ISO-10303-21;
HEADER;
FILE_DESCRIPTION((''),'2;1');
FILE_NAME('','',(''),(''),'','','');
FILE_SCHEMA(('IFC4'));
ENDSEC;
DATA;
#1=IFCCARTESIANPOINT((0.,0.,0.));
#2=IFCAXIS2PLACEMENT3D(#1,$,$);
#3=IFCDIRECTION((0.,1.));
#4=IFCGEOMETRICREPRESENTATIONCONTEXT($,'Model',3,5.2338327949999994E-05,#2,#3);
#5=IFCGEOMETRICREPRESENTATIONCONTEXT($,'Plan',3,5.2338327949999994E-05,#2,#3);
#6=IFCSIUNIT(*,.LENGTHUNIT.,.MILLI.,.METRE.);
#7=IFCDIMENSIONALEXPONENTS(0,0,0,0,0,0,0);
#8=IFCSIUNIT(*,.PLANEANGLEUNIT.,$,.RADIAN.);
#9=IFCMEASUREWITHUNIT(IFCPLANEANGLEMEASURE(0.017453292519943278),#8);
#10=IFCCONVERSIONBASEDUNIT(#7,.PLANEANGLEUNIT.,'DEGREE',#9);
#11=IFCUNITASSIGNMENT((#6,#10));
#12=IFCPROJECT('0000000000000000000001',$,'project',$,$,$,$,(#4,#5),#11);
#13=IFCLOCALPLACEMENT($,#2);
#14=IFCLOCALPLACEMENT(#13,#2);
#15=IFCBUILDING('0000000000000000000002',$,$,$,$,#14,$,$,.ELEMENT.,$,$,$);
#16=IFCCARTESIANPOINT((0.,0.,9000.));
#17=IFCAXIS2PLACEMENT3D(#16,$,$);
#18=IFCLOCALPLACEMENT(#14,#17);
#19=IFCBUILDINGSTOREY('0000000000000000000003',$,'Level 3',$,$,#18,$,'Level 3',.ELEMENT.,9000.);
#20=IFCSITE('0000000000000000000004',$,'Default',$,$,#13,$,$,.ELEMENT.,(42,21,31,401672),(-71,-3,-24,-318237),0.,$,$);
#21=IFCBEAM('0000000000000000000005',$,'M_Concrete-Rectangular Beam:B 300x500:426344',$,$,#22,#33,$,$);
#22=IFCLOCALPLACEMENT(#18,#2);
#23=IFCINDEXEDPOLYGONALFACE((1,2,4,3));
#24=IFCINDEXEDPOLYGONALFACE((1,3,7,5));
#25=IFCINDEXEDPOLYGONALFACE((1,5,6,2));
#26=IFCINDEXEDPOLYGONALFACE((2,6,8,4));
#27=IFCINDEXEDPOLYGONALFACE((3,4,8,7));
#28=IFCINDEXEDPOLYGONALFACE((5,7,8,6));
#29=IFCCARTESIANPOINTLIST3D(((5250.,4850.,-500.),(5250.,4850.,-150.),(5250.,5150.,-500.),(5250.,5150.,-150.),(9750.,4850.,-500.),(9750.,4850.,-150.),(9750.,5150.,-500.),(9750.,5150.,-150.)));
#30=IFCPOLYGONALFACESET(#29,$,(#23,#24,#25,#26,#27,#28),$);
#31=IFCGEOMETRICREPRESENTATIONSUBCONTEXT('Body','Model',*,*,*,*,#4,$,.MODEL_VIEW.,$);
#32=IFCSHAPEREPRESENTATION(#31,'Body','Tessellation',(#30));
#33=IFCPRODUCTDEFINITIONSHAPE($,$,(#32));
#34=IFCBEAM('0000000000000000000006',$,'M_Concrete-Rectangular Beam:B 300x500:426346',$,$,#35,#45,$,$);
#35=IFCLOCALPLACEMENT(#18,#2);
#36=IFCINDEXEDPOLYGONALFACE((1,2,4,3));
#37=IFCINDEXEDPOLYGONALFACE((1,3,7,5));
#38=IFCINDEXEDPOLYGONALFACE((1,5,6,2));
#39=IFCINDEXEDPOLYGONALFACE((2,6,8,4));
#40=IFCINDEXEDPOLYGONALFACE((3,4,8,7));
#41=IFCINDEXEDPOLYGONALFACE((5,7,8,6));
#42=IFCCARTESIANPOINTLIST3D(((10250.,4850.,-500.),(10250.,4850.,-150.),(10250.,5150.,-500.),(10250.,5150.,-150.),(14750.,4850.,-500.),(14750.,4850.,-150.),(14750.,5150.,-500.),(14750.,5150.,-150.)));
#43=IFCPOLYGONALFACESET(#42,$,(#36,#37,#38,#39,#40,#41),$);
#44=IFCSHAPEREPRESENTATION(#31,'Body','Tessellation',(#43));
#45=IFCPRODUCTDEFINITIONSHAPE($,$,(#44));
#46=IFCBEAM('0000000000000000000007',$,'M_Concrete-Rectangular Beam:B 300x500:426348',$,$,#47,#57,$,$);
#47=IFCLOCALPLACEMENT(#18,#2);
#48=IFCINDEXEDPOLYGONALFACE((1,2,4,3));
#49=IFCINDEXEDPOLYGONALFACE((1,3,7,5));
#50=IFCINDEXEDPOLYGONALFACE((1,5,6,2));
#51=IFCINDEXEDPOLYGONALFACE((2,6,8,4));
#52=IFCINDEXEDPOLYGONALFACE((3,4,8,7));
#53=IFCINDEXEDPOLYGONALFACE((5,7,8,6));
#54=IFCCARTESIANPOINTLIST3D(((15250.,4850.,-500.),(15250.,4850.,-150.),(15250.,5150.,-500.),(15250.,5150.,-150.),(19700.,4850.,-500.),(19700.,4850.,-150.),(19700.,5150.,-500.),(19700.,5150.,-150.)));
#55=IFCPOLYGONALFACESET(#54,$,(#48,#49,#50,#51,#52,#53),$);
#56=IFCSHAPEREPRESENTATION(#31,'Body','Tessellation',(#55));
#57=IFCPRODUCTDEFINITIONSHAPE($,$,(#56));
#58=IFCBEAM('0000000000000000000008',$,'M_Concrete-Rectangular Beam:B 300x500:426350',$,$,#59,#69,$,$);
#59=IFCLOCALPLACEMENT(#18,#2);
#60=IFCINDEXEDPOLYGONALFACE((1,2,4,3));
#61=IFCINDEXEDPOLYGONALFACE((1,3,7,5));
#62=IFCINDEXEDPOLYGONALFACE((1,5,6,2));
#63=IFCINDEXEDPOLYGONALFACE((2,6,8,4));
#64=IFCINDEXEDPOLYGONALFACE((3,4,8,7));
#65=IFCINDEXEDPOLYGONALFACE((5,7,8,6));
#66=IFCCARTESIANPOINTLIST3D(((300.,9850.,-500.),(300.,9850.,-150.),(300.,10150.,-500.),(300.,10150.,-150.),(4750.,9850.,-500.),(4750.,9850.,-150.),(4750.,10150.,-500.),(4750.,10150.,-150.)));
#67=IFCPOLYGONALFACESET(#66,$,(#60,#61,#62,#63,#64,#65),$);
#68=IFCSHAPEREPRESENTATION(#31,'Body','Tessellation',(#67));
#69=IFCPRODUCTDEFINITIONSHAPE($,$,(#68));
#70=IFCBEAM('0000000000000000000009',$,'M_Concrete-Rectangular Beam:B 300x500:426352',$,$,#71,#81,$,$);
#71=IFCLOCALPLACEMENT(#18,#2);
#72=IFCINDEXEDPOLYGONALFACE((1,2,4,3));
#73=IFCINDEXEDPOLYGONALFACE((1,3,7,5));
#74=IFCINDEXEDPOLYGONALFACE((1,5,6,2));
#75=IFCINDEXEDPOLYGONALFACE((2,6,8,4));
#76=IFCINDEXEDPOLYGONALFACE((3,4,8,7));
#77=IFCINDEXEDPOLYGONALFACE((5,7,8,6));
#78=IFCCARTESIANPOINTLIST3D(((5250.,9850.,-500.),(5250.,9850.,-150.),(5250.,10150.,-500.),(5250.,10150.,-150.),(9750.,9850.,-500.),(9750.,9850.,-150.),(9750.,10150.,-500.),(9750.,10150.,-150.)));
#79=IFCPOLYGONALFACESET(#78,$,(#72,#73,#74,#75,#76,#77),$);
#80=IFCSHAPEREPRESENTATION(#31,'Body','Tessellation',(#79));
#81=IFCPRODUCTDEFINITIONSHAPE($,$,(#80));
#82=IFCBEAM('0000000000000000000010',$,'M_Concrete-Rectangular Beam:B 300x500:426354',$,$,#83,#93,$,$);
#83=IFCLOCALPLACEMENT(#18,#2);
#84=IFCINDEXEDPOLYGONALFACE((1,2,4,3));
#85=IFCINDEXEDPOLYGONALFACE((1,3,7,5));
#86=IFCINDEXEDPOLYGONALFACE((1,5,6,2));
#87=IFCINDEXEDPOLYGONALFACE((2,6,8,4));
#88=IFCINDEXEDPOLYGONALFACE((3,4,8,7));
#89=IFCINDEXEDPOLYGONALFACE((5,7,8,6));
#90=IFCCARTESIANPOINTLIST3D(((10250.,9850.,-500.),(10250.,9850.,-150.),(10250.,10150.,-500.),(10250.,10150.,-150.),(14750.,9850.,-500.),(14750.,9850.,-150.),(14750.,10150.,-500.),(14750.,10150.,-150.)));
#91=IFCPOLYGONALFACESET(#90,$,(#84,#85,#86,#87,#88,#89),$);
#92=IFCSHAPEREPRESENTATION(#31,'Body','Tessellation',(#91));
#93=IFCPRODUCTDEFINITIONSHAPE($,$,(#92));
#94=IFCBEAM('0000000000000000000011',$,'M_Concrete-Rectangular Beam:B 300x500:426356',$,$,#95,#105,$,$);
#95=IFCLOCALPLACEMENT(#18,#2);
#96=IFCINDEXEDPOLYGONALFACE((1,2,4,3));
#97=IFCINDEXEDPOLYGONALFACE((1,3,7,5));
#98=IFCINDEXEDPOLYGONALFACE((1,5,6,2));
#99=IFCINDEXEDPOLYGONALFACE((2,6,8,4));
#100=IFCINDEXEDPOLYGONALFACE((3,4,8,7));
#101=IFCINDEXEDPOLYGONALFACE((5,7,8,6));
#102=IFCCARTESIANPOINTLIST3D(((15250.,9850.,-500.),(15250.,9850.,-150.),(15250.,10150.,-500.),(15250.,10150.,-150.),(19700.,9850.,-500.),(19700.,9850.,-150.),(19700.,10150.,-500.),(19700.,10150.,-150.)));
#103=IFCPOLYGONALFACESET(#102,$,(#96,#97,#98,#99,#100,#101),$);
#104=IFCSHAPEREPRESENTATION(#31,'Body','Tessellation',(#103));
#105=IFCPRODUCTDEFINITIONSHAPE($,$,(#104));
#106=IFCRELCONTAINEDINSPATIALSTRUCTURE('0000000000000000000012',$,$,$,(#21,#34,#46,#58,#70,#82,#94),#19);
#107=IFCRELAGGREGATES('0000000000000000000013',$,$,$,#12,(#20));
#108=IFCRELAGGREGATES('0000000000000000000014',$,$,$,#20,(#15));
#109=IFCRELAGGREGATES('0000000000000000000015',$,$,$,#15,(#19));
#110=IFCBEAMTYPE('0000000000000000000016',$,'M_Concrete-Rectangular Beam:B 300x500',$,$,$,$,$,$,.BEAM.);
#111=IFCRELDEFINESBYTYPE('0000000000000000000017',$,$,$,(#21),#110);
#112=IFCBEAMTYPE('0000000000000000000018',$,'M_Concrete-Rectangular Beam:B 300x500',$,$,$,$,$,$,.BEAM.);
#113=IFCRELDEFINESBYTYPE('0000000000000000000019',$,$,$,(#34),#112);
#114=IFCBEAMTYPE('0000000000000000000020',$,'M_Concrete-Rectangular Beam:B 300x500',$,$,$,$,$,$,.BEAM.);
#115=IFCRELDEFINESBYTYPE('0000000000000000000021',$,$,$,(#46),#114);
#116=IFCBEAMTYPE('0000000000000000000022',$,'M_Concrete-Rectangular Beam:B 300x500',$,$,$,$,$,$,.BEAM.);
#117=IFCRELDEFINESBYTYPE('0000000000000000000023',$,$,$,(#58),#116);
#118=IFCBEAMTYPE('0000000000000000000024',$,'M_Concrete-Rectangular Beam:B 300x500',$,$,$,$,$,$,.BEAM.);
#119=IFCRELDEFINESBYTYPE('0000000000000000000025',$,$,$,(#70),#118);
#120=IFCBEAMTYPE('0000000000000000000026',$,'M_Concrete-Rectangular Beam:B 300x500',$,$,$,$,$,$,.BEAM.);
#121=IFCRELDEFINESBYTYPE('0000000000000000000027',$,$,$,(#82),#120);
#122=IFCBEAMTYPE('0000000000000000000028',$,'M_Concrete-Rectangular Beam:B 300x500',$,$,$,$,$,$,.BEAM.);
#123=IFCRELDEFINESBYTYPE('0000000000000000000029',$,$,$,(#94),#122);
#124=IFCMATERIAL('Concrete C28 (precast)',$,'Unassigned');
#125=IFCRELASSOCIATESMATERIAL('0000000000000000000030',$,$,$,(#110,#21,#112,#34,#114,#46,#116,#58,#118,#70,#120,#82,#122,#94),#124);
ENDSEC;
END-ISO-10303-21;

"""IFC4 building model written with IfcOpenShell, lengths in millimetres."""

from ifc_helpers import new_model, entity, si_unit, converted_unit, direction, frame, origin, place, context, subcontext, project, spatial, indexed_curve, outline, extrude, source, transform, mapped, material, type_object, type_shapes, element, save


model = new_model("IFC4")

# Units and contexts
model_context = context("Model", 3, precision=5.2338327949999994e-05, world=origin(), true_north=direction((0.0, 1.0)))
plan_context = context("Plan", 3, precision=5.2338327949999994e-05, world=origin(), true_north=direction((0.0, 1.0)))
body_context = subcontext(model_context, "Body", "Model", "MODEL_VIEW")
ifc_project = project(units=[si_unit("LENGTHUNIT", "METRE", prefix="MILLI"), converted_unit("PLANEANGLEUNIT", "DEGREE", entity("IfcPlaneAngleMeasure", 0.017453292519943278), si_unit("PLANEANGLEUNIT", "RADIAN"), dimensions=[0, 0, 0, 0, 0, 0, 0])], contexts=[model_context, plan_context])

# Site, building, storey
site_placement = place(None, origin())
site = spatial("IfcSite", under=ifc_project, at=site_placement, Name="Default", CompositionType="ELEMENT", RefLatitude=(42, 21, 31, 401672), RefLongitude=(-71, -3, -24, -318237), RefElevation=0.0)
building_placement = place(site_placement, origin())
building = spatial("IfcBuilding", under=site, at=building_placement, CompositionType="ELEMENT")
storey_placement = place(building_placement, frame((0.0, 0.0, 9000.0)))
storey = spatial("IfcBuildingStorey", under=building, at=storey_placement, Name="Level 3", LongName="Level 3", CompositionType="ELEMENT", Elevation=9000.0)

# Shared definitions
ifc_material = material(Name="Concrete C28 (precast)", Category="Unassigned")

# Beams
beam_type_1 = type_object("IfcBeamType", Name="M_Concrete-Rectangular Beam:B 300x500", PredefinedType="BEAM", material=ifc_material)
shared_shape_1 = source(origin(), body_context, "Body", "SweptSolid", [
    extrude(outline(indexed_curve([(-175.0, -150.0), (175.0, -150.0), (175.0, 150.0), (-175.0, 150.0), (-175.0, -150.0)], self_intersect=False)), frame((5250.0, 5000.0, 8675.0), z_axis=(1.0, 0.0, 0.0), x_axis=(0.0, 0.0, -1.0)), (0.0, 0.0, 1.0), 4500.0),
])
type_shapes(beam_type_1, [shared_shape_1])
beam_1_placement = place(storey_placement, frame((0.0, 0.0, -9000.0)))
element("IfcBeam", 1, at=beam_1_placement, inside=storey, type_object=beam_type_1, material=ifc_material, Name="M_Concrete-Rectangular Beam:B 300x500:426344", context=body_context, shape_type="MappedRepresentation", body=[
    mapped(shared_shape_1, transform((0.0, 0.0, 0.0), scale=1.0)),
])
beam_type_2 = type_object("IfcBeamType", Name="M_Concrete-Rectangular Beam:B 300x500", PredefinedType="BEAM", material=ifc_material)
shared_shape_2 = source(origin(), body_context, "Body", "SweptSolid", [
    extrude(outline(indexed_curve([(-175.0, -150.0), (175.0, -150.0), (175.0, 150.0), (-175.0, 150.0), (-175.0, -150.0)], self_intersect=False)), frame((10250.0, 5000.0, 8675.0), z_axis=(1.0, 0.0, 0.0), x_axis=(0.0, 0.0, -1.0)), (0.0, 0.0, 1.0), 4500.0),
])
type_shapes(beam_type_2, [shared_shape_2])
beam_2_placement = place(storey_placement, frame((0.0, 0.0, -9000.0)))
element("IfcBeam", 2, at=beam_2_placement, inside=storey, type_object=beam_type_2, material=ifc_material, Name="M_Concrete-Rectangular Beam:B 300x500:426346", context=body_context, shape_type="MappedRepresentation", body=[
    mapped(shared_shape_2, transform((0.0, 0.0, 0.0), scale=1.0)),
])
beam_type_3 = type_object("IfcBeamType", Name="M_Concrete-Rectangular Beam:B 300x500", PredefinedType="BEAM", material=ifc_material)
shared_shape_3 = source(origin(), body_context, "Body", "SweptSolid", [
    extrude(outline(indexed_curve([(-175.0, -150.0), (175.0, -150.0), (175.0, 150.0), (-175.0, 150.0), (-175.0, -150.0)], self_intersect=False)), frame((15250.0, 5000.0, 8675.0), z_axis=(1.0, 0.0, 0.0), x_axis=(0.0, 0.0, -1.0)), (0.0, 0.0, 1.0), 4450.0),
])
type_shapes(beam_type_3, [shared_shape_3])
beam_3_placement = place(storey_placement, frame((0.0, 0.0, -9000.0)))
element("IfcBeam", 3, at=beam_3_placement, inside=storey, type_object=beam_type_3, material=ifc_material, Name="M_Concrete-Rectangular Beam:B 300x500:426348", context=body_context, shape_type="MappedRepresentation", body=[
    mapped(shared_shape_3, transform((0.0, 0.0, 0.0), scale=1.0)),
])
beam_type_4 = type_object("IfcBeamType", Name="M_Concrete-Rectangular Beam:B 300x500", PredefinedType="BEAM", material=ifc_material)
shared_shape_4 = source(origin(), body_context, "Body", "SweptSolid", [
    extrude(outline(indexed_curve([(-175.0, -150.0), (175.0, -150.0), (175.0, 150.0), (-175.0, 150.0), (-175.0, -150.0)], self_intersect=False)), frame((300.0, 10000.0, 8675.0), z_axis=(1.0, 0.0, 0.0), x_axis=(0.0, 0.0, -1.0)), (0.0, 0.0, 1.0), 4450.0),
])
type_shapes(beam_type_4, [shared_shape_4])
beam_4_placement = place(storey_placement, frame((0.0, 0.0, -9000.0)))
element("IfcBeam", 4, at=beam_4_placement, inside=storey, type_object=beam_type_4, material=ifc_material, Name="M_Concrete-Rectangular Beam:B 300x500:426350", context=body_context, shape_type="MappedRepresentation", body=[
    mapped(shared_shape_4, transform((0.0, 0.0, 0.0), scale=1.0)),
])
beam_type_5 = type_object("IfcBeamType", Name="M_Concrete-Rectangular Beam:B 300x500", PredefinedType="BEAM", material=ifc_material)
shared_shape_5 = source(origin(), body_context, "Body", "SweptSolid", [
    extrude(outline(indexed_curve([(-175.0, -150.0), (175.0, -150.0), (175.0, 150.0), (-175.0, 150.0), (-175.0, -150.0)], self_intersect=False)), frame((5250.0, 10000.0, 8675.0), z_axis=(1.0, 0.0, 0.0), x_axis=(0.0, 0.0, -1.0)), (0.0, 0.0, 1.0), 4500.0),
])
type_shapes(beam_type_5, [shared_shape_5])
beam_5_placement = place(storey_placement, frame((0.0, 0.0, -9000.0)))
element("IfcBeam", 5, at=beam_5_placement, inside=storey, type_object=beam_type_5, material=ifc_material, Name="M_Concrete-Rectangular Beam:B 300x500:426352", context=body_context, shape_type="MappedRepresentation", body=[
    mapped(shared_shape_5, transform((0.0, 0.0, 0.0), scale=1.0)),
])
beam_type_6 = type_object("IfcBeamType", Name="M_Concrete-Rectangular Beam:B 300x500", PredefinedType="BEAM", material=ifc_material)
shared_shape_6 = source(origin(), body_context, "Body", "SweptSolid", [
    extrude(outline(indexed_curve([(-175.0, -150.0), (175.0, -150.0), (175.0, 150.0), (-175.0, 150.0), (-175.0, -150.0)], self_intersect=False)), frame((10250.0, 10000.0, 8675.0), z_axis=(1.0, 0.0, 0.0), x_axis=(0.0, 0.0, -1.0)), (0.0, 0.0, 1.0), 4500.0),
])
type_shapes(beam_type_6, [shared_shape_6])
beam_6_placement = place(storey_placement, frame((0.0, 0.0, -9000.0)))
element("IfcBeam", 6, at=beam_6_placement, inside=storey, type_object=beam_type_6, material=ifc_material, Name="M_Concrete-Rectangular Beam:B 300x500:426354", context=body_context, shape_type="MappedRepresentation", body=[
    mapped(shared_shape_6, transform((0.0, 0.0, 0.0), scale=1.0)),
])
beam_type_7 = type_object("IfcBeamType", Name="M_Concrete-Rectangular Beam:B 300x500", PredefinedType="BEAM", material=ifc_material)
shared_shape_7 = source(origin(), body_context, "Body", "SweptSolid", [
    extrude(outline(indexed_curve([(-175.0, -150.0), (175.0, -150.0), (175.0, 150.0), (-175.0, 150.0), (-175.0, -150.0)], self_intersect=False)), frame((15250.0, 10000.0, 8675.0), z_axis=(1.0, 0.0, 0.0), x_axis=(0.0, 0.0, -1.0)), (0.0, 0.0, 1.0), 4450.0),
])
type_shapes(beam_type_7, [shared_shape_7])
beam_7_placement = place(storey_placement, frame((0.0, 0.0, -9000.0)))
element("IfcBeam", 7, at=beam_7_placement, inside=storey, type_object=beam_type_7, material=ifc_material, Name="M_Concrete-Rectangular Beam:B 300x500:426356", context=body_context, shape_type="MappedRepresentation", body=[
    mapped(shared_shape_7, transform((0.0, 0.0, 0.0), scale=1.0)),
])

save(model, "model.ifc")
